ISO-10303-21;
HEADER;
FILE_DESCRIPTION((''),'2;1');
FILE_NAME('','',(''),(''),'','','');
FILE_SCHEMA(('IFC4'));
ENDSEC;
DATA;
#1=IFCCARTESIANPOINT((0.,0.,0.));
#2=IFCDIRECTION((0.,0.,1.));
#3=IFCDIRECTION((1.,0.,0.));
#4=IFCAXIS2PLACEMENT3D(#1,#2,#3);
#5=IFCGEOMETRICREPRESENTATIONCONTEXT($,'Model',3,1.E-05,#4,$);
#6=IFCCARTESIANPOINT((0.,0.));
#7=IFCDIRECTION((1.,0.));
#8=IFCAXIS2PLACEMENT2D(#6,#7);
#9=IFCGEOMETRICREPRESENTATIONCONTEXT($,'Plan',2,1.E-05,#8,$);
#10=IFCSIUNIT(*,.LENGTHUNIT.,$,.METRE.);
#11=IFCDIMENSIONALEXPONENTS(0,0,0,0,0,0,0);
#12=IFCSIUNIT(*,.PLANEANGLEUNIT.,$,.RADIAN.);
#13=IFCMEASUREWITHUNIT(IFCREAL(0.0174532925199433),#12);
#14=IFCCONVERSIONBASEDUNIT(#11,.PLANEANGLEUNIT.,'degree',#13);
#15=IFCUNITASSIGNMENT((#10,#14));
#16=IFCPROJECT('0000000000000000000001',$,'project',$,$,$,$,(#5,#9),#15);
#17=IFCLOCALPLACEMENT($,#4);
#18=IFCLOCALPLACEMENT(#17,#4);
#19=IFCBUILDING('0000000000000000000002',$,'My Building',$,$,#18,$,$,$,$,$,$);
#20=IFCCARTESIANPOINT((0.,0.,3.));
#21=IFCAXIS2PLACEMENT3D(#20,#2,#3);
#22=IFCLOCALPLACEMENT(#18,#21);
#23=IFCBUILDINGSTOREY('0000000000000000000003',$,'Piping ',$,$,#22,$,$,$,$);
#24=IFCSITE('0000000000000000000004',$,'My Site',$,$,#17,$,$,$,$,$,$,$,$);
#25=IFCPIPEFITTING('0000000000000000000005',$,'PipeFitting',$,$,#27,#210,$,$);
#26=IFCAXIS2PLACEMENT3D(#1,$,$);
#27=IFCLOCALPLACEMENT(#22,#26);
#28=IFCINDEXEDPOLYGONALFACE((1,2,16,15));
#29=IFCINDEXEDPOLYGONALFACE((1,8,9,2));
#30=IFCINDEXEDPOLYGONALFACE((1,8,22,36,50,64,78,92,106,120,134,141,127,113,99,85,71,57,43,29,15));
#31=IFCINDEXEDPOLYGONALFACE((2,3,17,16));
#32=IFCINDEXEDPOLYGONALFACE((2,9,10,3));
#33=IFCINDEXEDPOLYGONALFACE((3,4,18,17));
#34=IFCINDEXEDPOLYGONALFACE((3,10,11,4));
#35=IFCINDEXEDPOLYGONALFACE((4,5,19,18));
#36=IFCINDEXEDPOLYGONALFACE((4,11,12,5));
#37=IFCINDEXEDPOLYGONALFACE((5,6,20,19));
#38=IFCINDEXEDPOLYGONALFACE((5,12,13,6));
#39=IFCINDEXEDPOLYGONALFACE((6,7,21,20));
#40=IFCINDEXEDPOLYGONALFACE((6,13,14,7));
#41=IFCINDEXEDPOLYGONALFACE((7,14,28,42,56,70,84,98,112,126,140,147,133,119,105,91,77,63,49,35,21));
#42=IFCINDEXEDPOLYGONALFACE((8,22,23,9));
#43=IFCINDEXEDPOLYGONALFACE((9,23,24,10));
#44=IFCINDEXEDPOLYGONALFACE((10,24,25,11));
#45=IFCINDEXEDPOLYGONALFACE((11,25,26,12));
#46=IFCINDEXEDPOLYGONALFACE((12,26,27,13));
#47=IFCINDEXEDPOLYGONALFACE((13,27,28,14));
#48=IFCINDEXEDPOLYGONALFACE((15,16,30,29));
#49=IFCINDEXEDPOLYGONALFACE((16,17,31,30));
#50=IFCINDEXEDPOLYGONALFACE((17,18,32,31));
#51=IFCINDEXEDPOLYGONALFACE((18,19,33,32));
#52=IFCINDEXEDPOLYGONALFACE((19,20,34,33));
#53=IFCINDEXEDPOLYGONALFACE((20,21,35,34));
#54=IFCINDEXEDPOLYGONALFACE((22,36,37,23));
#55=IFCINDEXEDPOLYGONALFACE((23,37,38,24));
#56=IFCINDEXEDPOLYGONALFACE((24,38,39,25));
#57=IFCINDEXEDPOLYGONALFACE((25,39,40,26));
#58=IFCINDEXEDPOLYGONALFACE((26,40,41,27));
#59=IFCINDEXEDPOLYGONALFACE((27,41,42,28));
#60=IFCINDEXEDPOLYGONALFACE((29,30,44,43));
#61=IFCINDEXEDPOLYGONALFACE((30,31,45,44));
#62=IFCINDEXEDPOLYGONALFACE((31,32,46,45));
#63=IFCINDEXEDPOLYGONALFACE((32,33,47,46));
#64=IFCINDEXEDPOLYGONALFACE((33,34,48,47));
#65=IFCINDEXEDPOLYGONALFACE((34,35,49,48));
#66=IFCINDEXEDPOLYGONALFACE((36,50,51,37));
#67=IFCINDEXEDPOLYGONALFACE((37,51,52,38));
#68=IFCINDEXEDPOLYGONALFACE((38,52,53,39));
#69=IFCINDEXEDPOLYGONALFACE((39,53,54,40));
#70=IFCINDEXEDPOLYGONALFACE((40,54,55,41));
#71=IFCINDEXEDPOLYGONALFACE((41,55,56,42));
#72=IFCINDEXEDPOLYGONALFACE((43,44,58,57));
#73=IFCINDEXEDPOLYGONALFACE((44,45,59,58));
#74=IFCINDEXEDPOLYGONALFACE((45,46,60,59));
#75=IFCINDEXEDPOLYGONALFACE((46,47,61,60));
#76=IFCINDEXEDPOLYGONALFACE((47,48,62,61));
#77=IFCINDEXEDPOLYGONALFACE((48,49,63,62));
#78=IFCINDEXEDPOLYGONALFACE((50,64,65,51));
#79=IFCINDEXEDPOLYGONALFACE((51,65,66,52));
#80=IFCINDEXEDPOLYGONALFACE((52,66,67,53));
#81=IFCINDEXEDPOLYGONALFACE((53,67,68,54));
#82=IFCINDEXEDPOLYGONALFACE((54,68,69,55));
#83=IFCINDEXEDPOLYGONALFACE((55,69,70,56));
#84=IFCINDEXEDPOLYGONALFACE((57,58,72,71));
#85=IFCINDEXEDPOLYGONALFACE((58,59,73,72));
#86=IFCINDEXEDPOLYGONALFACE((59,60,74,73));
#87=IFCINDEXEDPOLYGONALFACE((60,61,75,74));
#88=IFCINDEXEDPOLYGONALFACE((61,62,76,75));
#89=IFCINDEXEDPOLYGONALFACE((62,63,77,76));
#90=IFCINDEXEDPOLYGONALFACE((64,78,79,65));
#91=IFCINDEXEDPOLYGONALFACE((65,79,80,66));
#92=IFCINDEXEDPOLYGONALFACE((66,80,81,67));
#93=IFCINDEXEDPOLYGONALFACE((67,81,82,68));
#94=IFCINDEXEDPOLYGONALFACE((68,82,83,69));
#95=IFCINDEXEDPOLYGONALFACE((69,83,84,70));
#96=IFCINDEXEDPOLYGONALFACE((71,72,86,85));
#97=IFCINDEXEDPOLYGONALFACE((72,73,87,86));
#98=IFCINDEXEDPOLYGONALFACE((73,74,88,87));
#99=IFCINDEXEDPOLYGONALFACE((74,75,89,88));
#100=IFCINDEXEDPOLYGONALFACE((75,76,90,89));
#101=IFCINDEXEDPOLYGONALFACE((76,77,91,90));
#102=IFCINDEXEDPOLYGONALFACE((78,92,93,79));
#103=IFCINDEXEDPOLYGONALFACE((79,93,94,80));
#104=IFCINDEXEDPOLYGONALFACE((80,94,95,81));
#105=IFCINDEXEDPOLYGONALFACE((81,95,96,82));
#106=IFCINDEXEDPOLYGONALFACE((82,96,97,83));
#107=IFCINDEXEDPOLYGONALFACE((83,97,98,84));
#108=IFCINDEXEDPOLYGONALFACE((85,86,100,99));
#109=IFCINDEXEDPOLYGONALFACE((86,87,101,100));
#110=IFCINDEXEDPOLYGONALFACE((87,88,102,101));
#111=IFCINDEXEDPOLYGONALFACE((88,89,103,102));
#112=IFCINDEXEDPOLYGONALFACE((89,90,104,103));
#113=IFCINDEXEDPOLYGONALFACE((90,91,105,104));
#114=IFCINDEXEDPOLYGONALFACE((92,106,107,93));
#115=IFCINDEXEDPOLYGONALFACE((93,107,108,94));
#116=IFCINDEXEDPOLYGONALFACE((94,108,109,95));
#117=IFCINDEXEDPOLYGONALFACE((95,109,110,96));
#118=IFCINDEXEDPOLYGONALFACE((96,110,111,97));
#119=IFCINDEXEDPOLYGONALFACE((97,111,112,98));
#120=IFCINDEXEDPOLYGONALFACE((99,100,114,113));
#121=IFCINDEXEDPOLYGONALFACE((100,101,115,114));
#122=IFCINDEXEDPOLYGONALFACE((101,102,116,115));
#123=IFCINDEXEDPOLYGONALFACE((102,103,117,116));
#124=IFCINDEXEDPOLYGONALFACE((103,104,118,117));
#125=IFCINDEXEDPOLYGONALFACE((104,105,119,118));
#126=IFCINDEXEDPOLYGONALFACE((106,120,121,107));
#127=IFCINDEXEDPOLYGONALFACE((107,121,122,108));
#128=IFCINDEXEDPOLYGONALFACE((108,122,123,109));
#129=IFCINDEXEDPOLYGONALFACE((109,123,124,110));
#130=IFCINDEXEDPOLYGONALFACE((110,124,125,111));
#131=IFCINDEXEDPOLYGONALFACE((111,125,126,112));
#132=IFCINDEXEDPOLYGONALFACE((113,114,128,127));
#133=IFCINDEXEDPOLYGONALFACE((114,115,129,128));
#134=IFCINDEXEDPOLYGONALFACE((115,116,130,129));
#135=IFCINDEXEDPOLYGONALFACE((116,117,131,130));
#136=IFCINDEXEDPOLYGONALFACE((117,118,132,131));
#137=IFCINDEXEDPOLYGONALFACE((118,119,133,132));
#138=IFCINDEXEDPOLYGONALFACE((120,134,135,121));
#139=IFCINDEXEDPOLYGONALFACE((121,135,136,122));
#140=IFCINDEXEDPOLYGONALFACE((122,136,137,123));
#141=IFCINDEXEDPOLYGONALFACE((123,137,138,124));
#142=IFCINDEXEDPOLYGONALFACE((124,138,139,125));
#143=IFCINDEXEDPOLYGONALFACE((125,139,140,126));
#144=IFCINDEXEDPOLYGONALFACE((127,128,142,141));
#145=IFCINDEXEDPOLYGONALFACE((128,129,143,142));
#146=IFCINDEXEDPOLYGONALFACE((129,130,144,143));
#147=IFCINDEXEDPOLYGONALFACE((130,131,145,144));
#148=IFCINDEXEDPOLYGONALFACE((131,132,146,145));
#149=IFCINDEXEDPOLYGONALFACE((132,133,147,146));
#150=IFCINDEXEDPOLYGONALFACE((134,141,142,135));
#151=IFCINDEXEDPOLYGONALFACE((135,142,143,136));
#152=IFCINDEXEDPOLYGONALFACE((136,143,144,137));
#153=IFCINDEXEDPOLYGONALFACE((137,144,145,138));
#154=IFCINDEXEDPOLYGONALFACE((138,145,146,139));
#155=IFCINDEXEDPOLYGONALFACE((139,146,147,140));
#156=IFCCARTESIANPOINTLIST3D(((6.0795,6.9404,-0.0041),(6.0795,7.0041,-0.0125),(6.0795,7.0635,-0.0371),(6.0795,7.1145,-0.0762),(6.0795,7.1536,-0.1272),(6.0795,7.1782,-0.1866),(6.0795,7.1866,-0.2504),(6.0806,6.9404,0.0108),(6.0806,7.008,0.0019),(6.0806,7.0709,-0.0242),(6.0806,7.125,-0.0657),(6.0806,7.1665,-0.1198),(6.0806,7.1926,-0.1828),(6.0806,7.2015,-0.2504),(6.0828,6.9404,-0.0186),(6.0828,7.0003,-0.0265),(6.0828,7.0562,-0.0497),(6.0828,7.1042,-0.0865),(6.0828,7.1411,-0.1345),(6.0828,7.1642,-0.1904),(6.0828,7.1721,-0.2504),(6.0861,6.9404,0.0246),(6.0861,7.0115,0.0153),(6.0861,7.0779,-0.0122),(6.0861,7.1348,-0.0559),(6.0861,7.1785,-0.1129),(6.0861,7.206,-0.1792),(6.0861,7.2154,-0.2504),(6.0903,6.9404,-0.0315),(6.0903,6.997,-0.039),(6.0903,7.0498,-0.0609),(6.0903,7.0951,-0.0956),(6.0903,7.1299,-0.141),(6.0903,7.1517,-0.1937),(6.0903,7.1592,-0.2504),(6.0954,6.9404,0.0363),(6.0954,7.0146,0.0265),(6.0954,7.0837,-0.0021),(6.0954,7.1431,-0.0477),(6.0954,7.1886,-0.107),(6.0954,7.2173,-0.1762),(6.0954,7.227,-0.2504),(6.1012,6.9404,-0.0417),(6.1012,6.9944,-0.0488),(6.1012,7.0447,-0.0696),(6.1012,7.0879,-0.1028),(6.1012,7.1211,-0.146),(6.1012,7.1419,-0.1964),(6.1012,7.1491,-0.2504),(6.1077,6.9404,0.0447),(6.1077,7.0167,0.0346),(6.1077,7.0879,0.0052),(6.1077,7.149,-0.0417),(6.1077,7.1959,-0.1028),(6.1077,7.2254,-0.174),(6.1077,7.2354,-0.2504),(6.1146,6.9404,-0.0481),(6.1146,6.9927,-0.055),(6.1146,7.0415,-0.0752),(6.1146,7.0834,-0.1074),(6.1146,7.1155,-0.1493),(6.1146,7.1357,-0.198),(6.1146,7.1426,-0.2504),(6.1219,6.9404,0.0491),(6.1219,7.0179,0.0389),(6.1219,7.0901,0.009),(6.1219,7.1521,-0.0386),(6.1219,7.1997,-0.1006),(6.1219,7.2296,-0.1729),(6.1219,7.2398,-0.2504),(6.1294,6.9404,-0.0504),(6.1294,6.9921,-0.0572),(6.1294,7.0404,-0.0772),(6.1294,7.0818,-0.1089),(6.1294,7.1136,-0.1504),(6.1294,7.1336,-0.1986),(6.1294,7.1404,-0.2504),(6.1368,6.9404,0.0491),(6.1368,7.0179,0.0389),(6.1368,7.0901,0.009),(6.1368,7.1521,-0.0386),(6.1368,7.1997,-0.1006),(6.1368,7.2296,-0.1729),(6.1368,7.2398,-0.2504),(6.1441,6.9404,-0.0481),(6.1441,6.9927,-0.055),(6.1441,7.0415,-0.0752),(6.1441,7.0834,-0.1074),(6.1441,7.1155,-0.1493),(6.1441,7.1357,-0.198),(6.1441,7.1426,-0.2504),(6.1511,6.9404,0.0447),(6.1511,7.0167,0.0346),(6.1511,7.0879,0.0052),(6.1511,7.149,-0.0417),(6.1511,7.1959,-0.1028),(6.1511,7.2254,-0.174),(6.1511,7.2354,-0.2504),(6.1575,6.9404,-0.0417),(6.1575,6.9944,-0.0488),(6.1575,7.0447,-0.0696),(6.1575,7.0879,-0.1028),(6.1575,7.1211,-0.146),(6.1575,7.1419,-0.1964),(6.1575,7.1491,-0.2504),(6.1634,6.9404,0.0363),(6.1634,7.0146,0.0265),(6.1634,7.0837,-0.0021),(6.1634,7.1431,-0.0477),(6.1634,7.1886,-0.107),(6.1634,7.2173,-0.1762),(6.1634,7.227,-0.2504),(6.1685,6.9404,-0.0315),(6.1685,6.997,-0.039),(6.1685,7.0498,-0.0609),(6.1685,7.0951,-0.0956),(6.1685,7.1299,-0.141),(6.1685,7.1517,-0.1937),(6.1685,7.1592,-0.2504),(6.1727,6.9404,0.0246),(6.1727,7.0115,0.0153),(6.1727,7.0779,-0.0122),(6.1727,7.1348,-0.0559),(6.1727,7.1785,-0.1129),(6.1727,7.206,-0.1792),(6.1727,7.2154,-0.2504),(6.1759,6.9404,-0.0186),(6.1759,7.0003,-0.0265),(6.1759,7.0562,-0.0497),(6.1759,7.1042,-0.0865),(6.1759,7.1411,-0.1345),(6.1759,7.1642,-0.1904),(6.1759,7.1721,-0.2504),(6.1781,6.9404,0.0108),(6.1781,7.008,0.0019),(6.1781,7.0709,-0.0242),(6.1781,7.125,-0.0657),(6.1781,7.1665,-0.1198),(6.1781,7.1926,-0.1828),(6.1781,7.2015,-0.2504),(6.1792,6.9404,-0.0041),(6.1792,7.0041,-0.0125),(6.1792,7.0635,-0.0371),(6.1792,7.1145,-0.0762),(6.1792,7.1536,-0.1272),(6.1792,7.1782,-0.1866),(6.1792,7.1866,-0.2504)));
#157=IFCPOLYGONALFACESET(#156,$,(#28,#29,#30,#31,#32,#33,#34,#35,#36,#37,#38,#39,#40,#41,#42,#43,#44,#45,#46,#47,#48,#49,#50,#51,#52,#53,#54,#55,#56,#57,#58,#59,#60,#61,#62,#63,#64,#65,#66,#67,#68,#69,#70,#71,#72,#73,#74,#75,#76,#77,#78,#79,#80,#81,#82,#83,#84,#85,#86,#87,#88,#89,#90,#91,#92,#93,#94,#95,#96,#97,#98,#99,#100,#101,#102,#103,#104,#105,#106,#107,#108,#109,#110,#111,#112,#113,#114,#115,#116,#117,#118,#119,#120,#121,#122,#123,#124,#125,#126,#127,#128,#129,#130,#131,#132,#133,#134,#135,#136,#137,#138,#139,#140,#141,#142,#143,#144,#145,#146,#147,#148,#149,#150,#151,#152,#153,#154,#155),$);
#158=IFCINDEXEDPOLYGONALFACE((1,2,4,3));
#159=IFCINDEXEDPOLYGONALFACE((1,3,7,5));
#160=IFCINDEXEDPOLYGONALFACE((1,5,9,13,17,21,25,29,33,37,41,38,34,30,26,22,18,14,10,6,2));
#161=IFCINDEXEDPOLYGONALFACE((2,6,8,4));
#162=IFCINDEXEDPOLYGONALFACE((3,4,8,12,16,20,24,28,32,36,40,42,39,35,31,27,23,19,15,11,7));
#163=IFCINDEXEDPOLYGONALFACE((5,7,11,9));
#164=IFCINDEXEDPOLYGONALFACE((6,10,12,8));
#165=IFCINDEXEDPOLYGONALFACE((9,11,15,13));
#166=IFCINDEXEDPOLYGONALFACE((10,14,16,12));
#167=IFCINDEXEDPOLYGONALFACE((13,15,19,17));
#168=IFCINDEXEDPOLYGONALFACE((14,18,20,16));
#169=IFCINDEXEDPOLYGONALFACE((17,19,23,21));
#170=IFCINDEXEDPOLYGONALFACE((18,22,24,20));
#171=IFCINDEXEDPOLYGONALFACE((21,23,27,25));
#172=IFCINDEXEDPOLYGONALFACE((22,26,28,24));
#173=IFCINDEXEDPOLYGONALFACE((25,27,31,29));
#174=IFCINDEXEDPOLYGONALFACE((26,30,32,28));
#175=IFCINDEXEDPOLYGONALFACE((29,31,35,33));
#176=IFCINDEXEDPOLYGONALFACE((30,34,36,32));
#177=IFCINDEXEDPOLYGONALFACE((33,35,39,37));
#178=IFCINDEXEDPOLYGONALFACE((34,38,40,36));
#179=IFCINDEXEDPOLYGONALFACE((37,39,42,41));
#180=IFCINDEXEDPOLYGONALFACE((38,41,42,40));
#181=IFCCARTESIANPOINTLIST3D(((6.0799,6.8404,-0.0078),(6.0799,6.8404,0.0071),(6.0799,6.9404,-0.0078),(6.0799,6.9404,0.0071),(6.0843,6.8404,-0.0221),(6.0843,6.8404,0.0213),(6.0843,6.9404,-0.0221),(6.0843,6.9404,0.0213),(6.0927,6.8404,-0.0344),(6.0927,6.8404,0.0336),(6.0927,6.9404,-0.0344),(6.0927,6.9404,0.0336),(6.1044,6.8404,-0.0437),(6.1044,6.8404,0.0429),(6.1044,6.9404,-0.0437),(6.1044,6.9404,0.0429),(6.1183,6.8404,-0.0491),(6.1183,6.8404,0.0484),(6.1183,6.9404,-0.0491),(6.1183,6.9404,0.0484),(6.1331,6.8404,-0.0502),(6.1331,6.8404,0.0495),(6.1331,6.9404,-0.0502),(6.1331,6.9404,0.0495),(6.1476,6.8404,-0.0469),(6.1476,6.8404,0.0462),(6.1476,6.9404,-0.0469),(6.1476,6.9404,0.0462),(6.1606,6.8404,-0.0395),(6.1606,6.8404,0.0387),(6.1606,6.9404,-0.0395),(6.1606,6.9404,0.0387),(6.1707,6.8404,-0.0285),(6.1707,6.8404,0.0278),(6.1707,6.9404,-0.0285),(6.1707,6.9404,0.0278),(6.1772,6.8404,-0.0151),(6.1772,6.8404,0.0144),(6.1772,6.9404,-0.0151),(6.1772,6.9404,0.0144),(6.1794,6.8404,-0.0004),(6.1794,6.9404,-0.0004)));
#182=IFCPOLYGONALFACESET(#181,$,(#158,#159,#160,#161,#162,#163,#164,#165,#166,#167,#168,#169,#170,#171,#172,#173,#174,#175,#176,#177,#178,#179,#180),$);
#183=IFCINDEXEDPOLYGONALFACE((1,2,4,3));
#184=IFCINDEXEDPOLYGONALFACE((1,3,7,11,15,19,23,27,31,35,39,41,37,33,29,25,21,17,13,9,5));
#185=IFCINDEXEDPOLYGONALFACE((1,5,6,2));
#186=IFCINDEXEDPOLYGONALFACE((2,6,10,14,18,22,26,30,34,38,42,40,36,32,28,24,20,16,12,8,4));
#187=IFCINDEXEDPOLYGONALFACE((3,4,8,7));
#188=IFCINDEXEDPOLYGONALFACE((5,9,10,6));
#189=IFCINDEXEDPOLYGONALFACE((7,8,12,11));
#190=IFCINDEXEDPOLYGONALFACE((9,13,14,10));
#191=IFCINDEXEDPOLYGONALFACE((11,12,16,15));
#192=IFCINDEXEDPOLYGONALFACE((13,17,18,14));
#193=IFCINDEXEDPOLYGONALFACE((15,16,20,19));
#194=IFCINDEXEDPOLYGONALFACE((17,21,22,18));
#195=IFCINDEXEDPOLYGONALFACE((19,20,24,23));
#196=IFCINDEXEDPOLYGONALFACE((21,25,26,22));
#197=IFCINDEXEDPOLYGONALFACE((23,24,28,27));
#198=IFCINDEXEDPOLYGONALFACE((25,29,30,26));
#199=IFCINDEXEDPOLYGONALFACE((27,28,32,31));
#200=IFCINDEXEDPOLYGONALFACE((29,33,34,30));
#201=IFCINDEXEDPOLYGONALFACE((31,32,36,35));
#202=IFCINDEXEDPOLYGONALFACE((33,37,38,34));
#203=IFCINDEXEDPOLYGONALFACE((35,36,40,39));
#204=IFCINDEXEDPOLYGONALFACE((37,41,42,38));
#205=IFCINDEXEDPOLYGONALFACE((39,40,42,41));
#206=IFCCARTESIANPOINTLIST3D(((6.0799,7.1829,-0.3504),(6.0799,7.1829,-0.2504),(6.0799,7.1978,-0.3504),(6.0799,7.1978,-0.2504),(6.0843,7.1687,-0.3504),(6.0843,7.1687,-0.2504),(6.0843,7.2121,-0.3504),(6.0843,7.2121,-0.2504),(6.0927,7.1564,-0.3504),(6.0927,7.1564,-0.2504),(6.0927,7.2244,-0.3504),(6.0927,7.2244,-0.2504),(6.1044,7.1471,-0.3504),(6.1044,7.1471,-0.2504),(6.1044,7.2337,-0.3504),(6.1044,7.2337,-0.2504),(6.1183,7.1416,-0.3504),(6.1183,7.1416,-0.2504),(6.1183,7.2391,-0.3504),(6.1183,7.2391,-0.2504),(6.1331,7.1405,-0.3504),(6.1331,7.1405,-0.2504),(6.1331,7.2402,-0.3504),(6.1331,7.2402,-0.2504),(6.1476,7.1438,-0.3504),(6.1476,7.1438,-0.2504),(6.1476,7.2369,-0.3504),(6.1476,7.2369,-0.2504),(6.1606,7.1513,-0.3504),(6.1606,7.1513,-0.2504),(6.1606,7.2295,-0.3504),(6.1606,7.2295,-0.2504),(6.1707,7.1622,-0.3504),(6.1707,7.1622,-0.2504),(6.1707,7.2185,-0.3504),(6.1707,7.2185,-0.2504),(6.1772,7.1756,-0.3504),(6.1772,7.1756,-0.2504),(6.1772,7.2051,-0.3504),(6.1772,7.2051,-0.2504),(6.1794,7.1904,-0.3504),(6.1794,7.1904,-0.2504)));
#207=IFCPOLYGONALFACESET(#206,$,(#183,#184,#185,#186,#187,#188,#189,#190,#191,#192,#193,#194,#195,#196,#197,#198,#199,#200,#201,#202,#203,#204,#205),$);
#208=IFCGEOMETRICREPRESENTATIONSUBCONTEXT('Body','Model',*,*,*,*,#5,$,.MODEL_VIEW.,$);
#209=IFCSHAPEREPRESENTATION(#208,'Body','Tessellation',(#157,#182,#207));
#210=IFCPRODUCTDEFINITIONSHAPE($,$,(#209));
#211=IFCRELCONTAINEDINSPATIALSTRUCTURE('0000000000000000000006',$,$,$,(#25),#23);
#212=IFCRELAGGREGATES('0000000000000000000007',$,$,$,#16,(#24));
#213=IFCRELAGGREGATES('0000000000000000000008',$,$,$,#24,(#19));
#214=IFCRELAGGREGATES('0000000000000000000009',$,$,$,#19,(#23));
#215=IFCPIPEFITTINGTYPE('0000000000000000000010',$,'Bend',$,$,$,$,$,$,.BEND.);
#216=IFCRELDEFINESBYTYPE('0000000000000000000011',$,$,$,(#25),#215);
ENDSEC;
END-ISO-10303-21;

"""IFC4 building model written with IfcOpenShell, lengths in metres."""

from ifc_helpers import new_model, entity, si_unit, converted_unit, frame, origin_with_axes, origin_2d_with_axis, place, context, subcontext, project, spatial, circle, extrude, source, transform, mapped, type_object, type_shapes, element, save


model = new_model("IFC4")

# Units and contexts
model_context = context("Model", 3, precision=1e-05, world=origin_with_axes())
plan_context = context("Plan", 2, precision=1e-05, world=origin_2d_with_axis())
body_context = subcontext(model_context, "Body", "Model", "MODEL_VIEW")
ifc_project = project(units=[si_unit("LENGTHUNIT", "METRE"), converted_unit("PLANEANGLEUNIT", "degree", entity("IfcReal", 0.0174532925199433), si_unit("PLANEANGLEUNIT", "RADIAN"), dimensions=[0, 0, 0, 0, 0, 0, 0])], contexts=[model_context, plan_context])

# Site, building, storey
site_placement = place(None, origin_with_axes())
site = spatial("IfcSite", under=ifc_project, at=site_placement, Name="My Site")
building_placement = place(site_placement, origin_with_axes())
building = spatial("IfcBuilding", under=site, at=building_placement, Name="My Building")
storey_placement = place(building_placement, frame((0.0, 0.0, 3.0), z_axis=(0.0, 0.0, 1.0), x_axis=(1.0, 0.0, 0.0)))
storey = spatial("IfcBuildingStorey", under=building, at=storey_placement, Name="Piping ")

# Pipe fitting
pipe_fitting_type = type_object("IfcPipeFittingType", Name="Bend", PredefinedType="BEND")
shared_shape = source(origin_with_axes(), body_context, "Body", "SolidModel", [
    entity("IfcSweptDiskSolid", entity("IfcIndexedPolyCurve", entity("IfcCartesianPointList3D", [[0.0, 0.0, -0.1], [0.0, -0.0732, -0.2768], [0.0, -0.25, -0.35]]), [entity("IfcArcIndex", [1, 2, 3])]), 0.05),
    extrude(circle(Radius=0.05), origin_with_axes(), (0.0, 0.0, -1.0), 0.1),
    extrude(circle(Radius=0.05), frame((0.0, -0.25, -0.35), z_axis=(0.0, -1.0, 0.0), x_axis=(1.0, 0.0, 0.0)), (0.0, 0.0, 1.0), 0.1),
])
type_shapes(pipe_fitting_type, [shared_shape])
for number, where, z_axis, x_axis, name in (
    (1, (6.1294, 6.8404, -0.0004), (0.0, -1.0, 0.0), (1.0, 0.0, 0.0), "PipeFitting"),
):
    element("IfcPipeFitting", number, at=place(storey_placement, frame(where, z_axis=z_axis, x_axis=x_axis)), inside=storey, type_object=pipe_fitting_type, Name=name, context=body_context, shape_type="MappedRepresentation", body=[
        mapped(shared_shape, transform((0.0, 0.0, 0.0), x_axis=(1.0, 0.0, 0.0), y_axis=(0.0, 1.0, 0.0), z_axis=(0.0, 0.0, 1.0), scale=1.0)),
    ])

save(model, "model.ifc")
